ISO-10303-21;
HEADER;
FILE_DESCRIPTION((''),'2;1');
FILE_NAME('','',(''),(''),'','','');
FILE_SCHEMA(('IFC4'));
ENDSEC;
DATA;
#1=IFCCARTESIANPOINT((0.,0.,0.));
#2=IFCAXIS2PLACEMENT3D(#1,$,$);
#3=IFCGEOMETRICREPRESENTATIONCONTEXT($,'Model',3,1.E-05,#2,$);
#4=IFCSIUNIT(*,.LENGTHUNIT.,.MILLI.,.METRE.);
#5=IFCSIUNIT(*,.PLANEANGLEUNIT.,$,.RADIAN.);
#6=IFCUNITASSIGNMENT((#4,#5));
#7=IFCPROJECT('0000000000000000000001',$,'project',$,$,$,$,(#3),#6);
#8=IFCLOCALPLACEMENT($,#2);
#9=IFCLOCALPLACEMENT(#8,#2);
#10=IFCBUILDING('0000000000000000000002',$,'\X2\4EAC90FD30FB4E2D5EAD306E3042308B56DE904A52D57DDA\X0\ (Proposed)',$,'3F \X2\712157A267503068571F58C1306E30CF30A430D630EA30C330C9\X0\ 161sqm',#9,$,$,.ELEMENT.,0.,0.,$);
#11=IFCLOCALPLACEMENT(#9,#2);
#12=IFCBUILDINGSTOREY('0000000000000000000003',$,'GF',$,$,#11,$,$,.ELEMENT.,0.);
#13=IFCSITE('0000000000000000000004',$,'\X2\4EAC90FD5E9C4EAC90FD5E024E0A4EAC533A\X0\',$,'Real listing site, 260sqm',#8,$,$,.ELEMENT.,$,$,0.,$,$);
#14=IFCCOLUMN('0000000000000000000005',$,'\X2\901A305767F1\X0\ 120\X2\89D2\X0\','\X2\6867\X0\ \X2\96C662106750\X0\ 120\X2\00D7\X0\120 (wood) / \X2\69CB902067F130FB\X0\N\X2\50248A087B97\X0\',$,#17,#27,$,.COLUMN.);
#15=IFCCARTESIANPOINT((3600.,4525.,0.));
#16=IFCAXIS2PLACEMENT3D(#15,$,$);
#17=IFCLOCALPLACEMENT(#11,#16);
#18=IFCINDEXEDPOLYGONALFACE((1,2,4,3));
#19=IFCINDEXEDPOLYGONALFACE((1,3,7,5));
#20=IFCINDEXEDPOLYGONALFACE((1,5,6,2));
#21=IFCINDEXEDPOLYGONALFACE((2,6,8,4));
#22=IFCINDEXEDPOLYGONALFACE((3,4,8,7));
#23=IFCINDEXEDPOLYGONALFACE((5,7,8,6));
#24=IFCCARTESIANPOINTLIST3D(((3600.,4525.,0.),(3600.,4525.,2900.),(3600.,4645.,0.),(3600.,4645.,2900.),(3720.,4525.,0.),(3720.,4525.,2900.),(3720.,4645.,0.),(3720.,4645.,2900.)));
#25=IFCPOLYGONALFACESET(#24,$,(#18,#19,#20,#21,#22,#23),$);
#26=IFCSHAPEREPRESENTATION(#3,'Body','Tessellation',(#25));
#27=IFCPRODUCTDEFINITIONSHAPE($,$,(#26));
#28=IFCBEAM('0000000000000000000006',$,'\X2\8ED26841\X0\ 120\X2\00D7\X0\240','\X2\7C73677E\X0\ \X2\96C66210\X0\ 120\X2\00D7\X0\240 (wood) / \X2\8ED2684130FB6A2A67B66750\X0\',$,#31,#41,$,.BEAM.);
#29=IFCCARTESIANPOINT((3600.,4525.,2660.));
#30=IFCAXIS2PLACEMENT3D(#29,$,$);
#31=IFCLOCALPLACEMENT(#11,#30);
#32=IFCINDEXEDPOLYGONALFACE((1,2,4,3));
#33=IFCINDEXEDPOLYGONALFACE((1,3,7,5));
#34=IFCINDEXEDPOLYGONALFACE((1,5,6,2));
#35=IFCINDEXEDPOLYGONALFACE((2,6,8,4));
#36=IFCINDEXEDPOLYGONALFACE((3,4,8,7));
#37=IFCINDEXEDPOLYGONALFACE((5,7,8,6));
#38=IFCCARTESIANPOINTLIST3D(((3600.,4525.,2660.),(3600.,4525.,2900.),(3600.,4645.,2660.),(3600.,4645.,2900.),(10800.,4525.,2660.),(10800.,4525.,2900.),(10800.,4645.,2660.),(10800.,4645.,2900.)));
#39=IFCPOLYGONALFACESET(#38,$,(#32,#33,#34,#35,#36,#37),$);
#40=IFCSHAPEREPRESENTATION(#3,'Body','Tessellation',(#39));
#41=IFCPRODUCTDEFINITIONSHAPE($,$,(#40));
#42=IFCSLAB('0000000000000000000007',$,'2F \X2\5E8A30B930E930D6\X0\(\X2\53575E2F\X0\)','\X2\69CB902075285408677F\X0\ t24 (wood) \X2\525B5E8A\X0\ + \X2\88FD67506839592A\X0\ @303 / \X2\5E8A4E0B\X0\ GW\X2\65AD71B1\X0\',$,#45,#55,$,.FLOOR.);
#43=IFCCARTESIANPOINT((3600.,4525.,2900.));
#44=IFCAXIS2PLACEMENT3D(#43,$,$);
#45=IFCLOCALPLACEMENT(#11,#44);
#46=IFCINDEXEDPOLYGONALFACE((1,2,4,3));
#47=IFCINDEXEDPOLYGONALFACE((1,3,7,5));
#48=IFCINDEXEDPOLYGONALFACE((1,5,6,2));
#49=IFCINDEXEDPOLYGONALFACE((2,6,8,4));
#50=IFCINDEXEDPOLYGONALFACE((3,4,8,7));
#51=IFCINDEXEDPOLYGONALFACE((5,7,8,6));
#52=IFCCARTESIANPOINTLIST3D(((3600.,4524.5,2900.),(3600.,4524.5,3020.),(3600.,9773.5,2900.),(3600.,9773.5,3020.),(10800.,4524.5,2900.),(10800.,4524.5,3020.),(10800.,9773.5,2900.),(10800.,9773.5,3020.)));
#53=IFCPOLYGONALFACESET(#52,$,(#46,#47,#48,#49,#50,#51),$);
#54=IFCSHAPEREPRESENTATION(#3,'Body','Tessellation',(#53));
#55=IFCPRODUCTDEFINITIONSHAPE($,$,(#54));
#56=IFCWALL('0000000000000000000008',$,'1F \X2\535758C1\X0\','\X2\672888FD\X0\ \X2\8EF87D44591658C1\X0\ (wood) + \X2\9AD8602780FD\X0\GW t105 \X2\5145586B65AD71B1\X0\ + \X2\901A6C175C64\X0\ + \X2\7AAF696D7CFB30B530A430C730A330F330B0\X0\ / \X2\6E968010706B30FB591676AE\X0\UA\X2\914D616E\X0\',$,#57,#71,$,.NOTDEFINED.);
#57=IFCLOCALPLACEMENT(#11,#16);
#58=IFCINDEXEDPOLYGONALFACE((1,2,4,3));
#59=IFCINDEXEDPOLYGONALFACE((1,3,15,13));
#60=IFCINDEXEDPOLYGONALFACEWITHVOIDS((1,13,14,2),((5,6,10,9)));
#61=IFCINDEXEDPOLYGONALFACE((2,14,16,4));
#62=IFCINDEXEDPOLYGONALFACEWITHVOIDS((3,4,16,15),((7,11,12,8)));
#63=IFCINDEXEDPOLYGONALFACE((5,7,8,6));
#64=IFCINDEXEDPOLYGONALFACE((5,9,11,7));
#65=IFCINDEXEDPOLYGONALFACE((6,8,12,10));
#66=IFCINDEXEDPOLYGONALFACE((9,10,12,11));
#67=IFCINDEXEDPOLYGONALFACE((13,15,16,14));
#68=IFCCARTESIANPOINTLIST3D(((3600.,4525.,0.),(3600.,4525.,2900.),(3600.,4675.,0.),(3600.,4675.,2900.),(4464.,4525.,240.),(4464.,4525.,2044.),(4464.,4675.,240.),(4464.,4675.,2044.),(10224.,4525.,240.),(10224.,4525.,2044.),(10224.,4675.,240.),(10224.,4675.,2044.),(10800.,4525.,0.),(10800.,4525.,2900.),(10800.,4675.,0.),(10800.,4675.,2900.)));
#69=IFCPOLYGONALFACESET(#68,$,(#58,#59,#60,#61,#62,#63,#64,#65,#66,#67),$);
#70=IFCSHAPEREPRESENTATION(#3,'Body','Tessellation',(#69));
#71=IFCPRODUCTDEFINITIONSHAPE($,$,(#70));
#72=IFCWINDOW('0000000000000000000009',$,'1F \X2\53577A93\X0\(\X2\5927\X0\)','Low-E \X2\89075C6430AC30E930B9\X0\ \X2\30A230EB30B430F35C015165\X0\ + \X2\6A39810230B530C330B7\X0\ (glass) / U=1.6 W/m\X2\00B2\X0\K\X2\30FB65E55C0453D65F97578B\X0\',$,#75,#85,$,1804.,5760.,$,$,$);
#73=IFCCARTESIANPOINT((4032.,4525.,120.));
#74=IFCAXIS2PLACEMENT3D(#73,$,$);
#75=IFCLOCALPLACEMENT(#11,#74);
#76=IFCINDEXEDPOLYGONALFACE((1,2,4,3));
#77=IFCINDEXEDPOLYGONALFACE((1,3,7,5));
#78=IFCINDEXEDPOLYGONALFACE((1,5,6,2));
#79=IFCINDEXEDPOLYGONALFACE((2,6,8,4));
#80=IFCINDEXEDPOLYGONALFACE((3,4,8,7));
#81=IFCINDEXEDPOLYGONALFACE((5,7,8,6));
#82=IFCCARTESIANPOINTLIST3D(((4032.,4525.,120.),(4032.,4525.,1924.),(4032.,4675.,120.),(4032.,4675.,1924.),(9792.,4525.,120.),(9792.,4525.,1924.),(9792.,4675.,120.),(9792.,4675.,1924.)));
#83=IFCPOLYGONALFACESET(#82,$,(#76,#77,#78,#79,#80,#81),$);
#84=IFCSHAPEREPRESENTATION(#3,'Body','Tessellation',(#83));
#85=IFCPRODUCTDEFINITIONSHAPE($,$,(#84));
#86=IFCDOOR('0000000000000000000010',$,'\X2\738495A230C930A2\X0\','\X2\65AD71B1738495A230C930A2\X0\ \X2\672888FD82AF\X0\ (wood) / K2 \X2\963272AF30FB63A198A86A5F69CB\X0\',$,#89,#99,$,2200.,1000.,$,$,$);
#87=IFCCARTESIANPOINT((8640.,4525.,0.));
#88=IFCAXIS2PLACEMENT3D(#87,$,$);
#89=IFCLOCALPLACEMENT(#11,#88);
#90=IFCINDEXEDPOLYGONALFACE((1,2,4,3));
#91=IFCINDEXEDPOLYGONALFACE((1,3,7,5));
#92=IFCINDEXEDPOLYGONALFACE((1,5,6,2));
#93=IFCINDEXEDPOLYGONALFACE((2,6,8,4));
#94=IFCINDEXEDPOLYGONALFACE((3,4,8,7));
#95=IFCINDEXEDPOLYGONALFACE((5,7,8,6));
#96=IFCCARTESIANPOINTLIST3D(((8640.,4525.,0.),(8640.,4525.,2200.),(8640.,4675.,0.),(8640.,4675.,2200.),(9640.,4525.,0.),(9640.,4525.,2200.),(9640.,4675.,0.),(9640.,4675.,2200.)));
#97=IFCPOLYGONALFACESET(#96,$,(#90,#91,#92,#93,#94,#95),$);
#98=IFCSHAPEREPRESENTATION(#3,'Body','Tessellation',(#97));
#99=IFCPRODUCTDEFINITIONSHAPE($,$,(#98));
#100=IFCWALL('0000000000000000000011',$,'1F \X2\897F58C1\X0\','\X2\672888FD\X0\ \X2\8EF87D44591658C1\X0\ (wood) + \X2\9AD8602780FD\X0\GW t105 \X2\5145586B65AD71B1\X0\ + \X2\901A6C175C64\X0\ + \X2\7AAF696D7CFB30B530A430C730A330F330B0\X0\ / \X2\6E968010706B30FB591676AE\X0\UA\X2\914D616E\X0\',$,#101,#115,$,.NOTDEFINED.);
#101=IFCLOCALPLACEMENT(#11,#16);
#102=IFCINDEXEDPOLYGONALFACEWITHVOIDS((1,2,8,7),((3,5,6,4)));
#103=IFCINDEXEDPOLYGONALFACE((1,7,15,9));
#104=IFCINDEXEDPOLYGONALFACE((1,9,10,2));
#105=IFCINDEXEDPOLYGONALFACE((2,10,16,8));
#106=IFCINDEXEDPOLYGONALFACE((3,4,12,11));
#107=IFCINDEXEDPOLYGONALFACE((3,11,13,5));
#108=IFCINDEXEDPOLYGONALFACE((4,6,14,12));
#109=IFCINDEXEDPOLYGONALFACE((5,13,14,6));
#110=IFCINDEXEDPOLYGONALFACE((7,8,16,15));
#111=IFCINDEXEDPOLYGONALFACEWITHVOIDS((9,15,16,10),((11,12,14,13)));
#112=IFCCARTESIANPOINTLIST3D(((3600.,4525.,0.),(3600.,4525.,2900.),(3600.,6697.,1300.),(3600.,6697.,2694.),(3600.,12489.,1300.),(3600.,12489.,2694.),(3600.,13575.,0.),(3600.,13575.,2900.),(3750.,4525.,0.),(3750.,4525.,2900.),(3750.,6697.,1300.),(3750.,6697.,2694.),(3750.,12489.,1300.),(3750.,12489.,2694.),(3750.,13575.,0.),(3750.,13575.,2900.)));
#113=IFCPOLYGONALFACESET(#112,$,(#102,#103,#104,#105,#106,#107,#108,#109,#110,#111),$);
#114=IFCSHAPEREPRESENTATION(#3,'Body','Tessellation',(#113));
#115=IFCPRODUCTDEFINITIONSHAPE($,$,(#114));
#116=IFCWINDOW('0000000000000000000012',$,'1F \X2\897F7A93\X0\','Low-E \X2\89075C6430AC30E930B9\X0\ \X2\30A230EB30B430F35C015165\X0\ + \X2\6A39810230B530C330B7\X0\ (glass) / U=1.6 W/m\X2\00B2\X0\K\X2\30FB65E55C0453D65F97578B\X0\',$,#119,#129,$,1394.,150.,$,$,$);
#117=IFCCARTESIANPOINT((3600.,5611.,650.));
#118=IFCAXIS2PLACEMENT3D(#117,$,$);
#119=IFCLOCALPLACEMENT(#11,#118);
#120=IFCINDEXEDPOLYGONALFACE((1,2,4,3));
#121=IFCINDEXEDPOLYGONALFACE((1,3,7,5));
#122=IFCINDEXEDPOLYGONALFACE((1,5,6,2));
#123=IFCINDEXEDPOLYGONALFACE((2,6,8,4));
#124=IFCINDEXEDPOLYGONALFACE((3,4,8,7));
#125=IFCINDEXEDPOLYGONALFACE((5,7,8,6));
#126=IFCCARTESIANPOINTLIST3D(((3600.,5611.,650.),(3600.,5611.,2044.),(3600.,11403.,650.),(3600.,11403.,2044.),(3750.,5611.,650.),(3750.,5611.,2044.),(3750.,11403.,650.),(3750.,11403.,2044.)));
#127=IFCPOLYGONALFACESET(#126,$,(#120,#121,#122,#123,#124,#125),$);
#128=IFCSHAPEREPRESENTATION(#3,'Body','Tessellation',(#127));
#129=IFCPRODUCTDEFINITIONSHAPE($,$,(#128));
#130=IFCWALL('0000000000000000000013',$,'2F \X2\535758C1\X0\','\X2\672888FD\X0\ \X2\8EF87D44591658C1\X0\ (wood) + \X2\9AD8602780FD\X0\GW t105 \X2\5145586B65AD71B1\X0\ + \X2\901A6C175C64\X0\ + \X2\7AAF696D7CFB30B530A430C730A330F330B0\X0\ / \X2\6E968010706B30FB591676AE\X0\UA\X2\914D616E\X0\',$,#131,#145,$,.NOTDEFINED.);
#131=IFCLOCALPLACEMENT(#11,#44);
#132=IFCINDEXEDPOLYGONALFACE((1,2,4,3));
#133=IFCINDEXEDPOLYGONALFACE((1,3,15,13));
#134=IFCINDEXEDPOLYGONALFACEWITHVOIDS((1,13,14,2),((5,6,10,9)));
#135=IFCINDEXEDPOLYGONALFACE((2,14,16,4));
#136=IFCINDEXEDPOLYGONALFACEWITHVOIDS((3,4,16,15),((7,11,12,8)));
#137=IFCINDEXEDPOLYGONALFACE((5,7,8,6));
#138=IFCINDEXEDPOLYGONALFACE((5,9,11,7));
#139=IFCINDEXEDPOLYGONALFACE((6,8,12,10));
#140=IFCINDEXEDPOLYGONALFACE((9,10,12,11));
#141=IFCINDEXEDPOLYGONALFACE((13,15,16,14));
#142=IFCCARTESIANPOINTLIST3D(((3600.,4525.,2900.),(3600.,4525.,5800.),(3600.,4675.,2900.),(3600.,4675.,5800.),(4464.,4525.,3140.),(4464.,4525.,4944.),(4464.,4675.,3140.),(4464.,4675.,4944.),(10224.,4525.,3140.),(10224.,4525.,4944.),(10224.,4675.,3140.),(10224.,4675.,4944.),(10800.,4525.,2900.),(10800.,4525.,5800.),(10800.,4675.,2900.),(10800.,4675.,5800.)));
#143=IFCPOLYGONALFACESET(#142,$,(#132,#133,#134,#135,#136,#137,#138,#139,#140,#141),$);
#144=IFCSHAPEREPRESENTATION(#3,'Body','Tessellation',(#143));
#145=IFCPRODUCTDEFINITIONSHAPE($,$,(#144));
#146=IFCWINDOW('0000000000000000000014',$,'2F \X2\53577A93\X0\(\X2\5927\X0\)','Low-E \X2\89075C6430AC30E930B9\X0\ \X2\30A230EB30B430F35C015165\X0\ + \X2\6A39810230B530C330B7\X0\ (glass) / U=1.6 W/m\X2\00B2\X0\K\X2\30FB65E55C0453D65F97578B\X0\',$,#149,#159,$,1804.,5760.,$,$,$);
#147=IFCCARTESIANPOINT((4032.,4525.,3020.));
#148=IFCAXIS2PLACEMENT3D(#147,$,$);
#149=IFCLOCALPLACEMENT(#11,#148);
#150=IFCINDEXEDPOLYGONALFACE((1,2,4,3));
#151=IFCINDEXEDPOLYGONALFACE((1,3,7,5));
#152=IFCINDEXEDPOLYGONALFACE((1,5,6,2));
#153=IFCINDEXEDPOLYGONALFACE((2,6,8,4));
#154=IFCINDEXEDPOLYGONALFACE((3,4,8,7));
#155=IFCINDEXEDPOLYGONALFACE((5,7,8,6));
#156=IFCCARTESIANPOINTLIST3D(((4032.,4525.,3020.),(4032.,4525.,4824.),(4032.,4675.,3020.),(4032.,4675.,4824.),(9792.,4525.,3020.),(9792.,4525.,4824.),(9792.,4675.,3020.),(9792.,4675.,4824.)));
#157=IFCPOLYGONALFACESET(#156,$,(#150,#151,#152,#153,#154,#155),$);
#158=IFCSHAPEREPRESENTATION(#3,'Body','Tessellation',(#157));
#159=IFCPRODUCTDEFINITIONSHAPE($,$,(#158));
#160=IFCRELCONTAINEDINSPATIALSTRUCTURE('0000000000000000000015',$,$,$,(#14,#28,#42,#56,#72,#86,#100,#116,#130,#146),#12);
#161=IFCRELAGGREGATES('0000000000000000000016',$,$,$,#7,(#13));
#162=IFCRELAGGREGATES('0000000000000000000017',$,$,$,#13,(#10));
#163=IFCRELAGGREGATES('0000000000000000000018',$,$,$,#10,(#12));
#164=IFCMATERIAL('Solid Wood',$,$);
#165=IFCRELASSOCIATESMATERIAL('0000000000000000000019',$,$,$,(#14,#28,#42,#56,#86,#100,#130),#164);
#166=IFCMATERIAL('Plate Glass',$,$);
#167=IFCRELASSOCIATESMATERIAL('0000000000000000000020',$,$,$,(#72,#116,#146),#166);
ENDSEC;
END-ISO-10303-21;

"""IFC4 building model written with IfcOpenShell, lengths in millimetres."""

from ifc_helpers import new_model, si_unit, frame, frame_2d, origin, place, context, project, spatial, rectangle, extrude, material, element, fill, save


model = new_model("IFC4")

# Units and contexts
model_context = context("Model", 3, precision=1e-05, world=origin())
ifc_project = project(units=[si_unit("LENGTHUNIT", "METRE", prefix="MILLI"), si_unit("PLANEANGLEUNIT", "RADIAN")], contexts=[model_context])

# Site, building, storey
site_placement = place(None, origin())
site = spatial("IfcSite", under=ifc_project, at=site_placement, Name="京都府京都市上京区", ObjectType="Real listing site, 260sqm", CompositionType="ELEMENT", RefElevation=0.0)
building_placement = place(site_placement, origin())
building = spatial("IfcBuilding", under=site, at=building_placement, Name="京都・中庭のある回遊動線 (Proposed)", ObjectType="3F 無垢材と土壁のハイブリッド 161sqm", CompositionType="ELEMENT", ElevationOfRefHeight=0.0, ElevationOfTerrain=0.0)
storey_placement = place(building_placement, origin())
storey = spatial("IfcBuildingStorey", under=building, at=storey_placement, Name="GF", CompositionType="ELEMENT", Elevation=0.0)

# Column
ifc_material_1 = material(Name="Solid Wood")
column_placement = place(storey_placement, frame((3600.0, 4525.0, 0.0)))
element("IfcColumn", 1, at=column_placement, inside=storey, material=ifc_material_1, Name="通し柱 120角", Description="桧 集成材 120×120 (wood) / 構造柱・N値計算", PredefinedType="COLUMN", context=model_context, shape_type="SweptSolid", body=[
    extrude(rectangle(XDim=120.0, YDim=120.0, at=frame_2d((60.0, 60.0))), frame((3600.0, 4525.0, 0.0)), (0.0, 0.0, 1.0), 2900.0),
])

# Beam
beam_1_placement = place(storey_placement, frame((3600.0, 4525.0, 2660.0)))
element("IfcBeam", 2, at=beam_1_placement, inside=storey, material=ifc_material_1, Name="軒桁 120×240", Description="米松 集成 120×240 (wood) / 軒桁・横架材", PredefinedType="BEAM", context=model_context, shape_type="SweptSolid", body=[
    extrude(rectangle(XDim=7200.0, YDim=120.0, at=frame_2d((3600.0, 60.0))), frame((3600.0, 4525.0, 2660.0)), (0.0, 0.0, 1.0), 240.0),
])

# Slab
slab_1_placement = place(storey_placement, frame((3600.0, 4525.0, 2900.0)))
element("IfcSlab", 3, at=slab_1_placement, inside=storey, material=ifc_material_1, Name="2F 床スラブ(南帯)", Description="構造用合板 t24 (wood) 剛床 + 製材根太 @303 / 床下 GW断熱", PredefinedType="FLOOR", context=model_context, shape_type="SweptSolid", body=[
    extrude(rectangle(XDim=7200.0, YDim=5249.0, at=frame_2d((3600.0, 2624.0))), frame((3600.0, 4525.0, 2900.0)), (0.0, 0.0, 1.0), 120.0),
])

# Wall, openings, window, door
wall_1_placement = place(storey_placement, frame((3600.0, 4525.0, 0.0)))
wall_1 = element("IfcWall", 4, at=wall_1_placement, inside=storey, material=ifc_material_1, Name="1F 南壁", Description="木製 軸組外壁 (wood) + 高性能GW t105 充填断熱 + 通気層 + 窯業系サイディング / 準耐火・外皮UA配慮", PredefinedType="NOTDEFINED", context=model_context, shape_type="SweptSolid", body=[
    extrude(rectangle(XDim=7200.0, YDim=150.0, at=frame_2d((3600.0, 75.0))), frame((3600.0, 4525.0, 0.0)), (0.0, 0.0, 1.0), 2900.0),
])
opening_1_placement = place(storey_placement, frame((4032.0, 4525.0, 120.0)))
opening_1 = element("IfcOpeningElement", 5, at=opening_1_placement, cuts=wall_1, PredefinedType="NOTDEFINED", context=model_context, shape_type="SweptSolid", body=[
    extrude(rectangle(XDim=5760.0, YDim=150.0, at=frame_2d((2880.0, 75.0))), frame((4032.0, 4525.0, 120.0)), (0.0, 0.0, 1.0), 1804.0),
])
opening_2_placement = place(storey_placement, frame((8640.0, 4525.0, 0.0)))
opening_2 = element("IfcOpeningElement", 6, at=opening_2_placement, cuts=wall_1, PredefinedType="NOTDEFINED", context=model_context, shape_type="SweptSolid", body=[
    extrude(rectangle(XDim=1000.0, YDim=150.0, at=frame_2d((500.0, 75.0))), frame((8640.0, 4525.0, 0.0)), (0.0, 0.0, 1.0), 2200.0),
])
ifc_material_2 = material(Name="Plate Glass")
window_1_placement = place(storey_placement, frame((4032.0, 4525.0, 120.0)))
window_1 = element("IfcWindow", 7, at=window_1_placement, inside=storey, material=ifc_material_2, Name="1F 南窓(大)", Description="Low-E 複層ガラス アルゴン封入 + 樹脂サッシ (glass) / U=1.6 W/m²K・日射取得型", OverallHeight=1804.0, OverallWidth=5760.0, context=model_context, shape_type="SweptSolid", body=[
    extrude(rectangle(XDim=5760.0, YDim=150.0, at=frame_2d((2880.0, 75.0))), frame((4032.0, 4525.0, 120.0)), (0.0, 0.0, 1.0), 1804.0),
])
fill(opening_1, window_1)
door_placement = place(storey_placement, frame((8640.0, 4525.0, 0.0)))
door = element("IfcDoor", 8, at=door_placement, inside=storey, material=ifc_material_1, Name="玄関ドア", Description="断熱玄関ドア 木製芯 (wood) / K2 防犯・採風機構", OverallHeight=2200.0, OverallWidth=1000.0, context=model_context, shape_type="SweptSolid", body=[
    extrude(rectangle(XDim=1000.0, YDim=150.0, at=frame_2d((500.0, 75.0))), frame((8640.0, 4525.0, 0.0)), (0.0, 0.0, 1.0), 2200.0),
])
fill(opening_2, door)

# Walls, openings, windows
wall_2_placement = place(storey_placement, frame((3600.0, 4525.0, 0.0)))
wall_2 = element("IfcWall", 9, at=wall_2_placement, inside=storey, material=ifc_material_1, Name="1F 西壁", Description="木製 軸組外壁 (wood) + 高性能GW t105 充填断熱 + 通気層 + 窯業系サイディング / 準耐火・外皮UA配慮", PredefinedType="NOTDEFINED", context=model_context, shape_type="SweptSolid", body=[
    extrude(rectangle(XDim=150.0, YDim=9050.0, at=frame_2d((75.0, 4525.0))), frame((3600.0, 4525.0, 0.0)), (0.0, 0.0, 1.0), 2900.0),
])
opening_3_placement = place(storey_placement, frame((3600.0, 5611.0, 650.0)))
opening_3 = element("IfcOpeningElement", 10, at=opening_3_placement, cuts=wall_2, PredefinedType="NOTDEFINED", context=model_context, shape_type="SweptSolid", body=[
    extrude(rectangle(XDim=150.0, YDim=5792.0, at=frame_2d((75.0, 2896.0))), frame((3600.0, 5611.0, 650.0)), (0.0, 0.0, 1.0), 1394.0),
])
window_2_placement = place(storey_placement, frame((3600.0, 5611.0, 650.0)))
window_2 = element("IfcWindow", 11, at=window_2_placement, inside=storey, material=ifc_material_2, Name="1F 西窓", Description="Low-E 複層ガラス アルゴン封入 + 樹脂サッシ (glass) / U=1.6 W/m²K・日射取得型", OverallHeight=1394.0, OverallWidth=150.0, context=model_context, shape_type="SweptSolid", body=[
    extrude(rectangle(XDim=150.0, YDim=5792.0, at=frame_2d((75.0, 2896.0))), frame((3600.0, 5611.0, 650.0)), (0.0, 0.0, 1.0), 1394.0),
])
fill(opening_3, window_2)
wall_3_placement = place(storey_placement, frame((3600.0, 4525.0, 2900.0)))
wall_3 = element("IfcWall", 12, at=wall_3_placement, inside=storey, material=ifc_material_1, Name="2F 南壁", Description="木製 軸組外壁 (wood) + 高性能GW t105 充填断熱 + 通気層 + 窯業系サイディング / 準耐火・外皮UA配慮", PredefinedType="NOTDEFINED", context=model_context, shape_type="SweptSolid", body=[
    extrude(rectangle(XDim=7200.0, YDim=150.0, at=frame_2d((3600.0, 75.0))), frame((3600.0, 4525.0, 2900.0)), (0.0, 0.0, 1.0), 2900.0),
])
opening_4_placement = place(storey_placement, frame((4032.0, 4525.0, 3020.0)))
opening_4 = element("IfcOpeningElement", 13, at=opening_4_placement, cuts=wall_3, PredefinedType="NOTDEFINED", context=model_context, shape_type="SweptSolid", body=[
    extrude(rectangle(XDim=5760.0, YDim=150.0, at=frame_2d((2880.0, 75.0))), frame((4032.0, 4525.0, 3020.0)), (0.0, 0.0, 1.0), 1804.0),
])
window_3_placement = place(storey_placement, frame((4032.0, 4525.0, 3020.0)))
window_3 = element("IfcWindow", 14, at=window_3_placement, inside=storey, material=ifc_material_2, Name="2F 南窓(大)", Description="Low-E 複層ガラス アルゴン封入 + 樹脂サッシ (glass) / U=1.6 W/m²K・日射取得型", OverallHeight=1804.0, OverallWidth=5760.0, context=model_context, shape_type="SweptSolid", body=[
    extrude(rectangle(XDim=5760.0, YDim=150.0, at=frame_2d((2880.0, 75.0))), frame((4032.0, 4525.0, 3020.0)), (0.0, 0.0, 1.0), 1804.0),
])
fill(opening_4, window_3)

save(model, "model.ifc")
